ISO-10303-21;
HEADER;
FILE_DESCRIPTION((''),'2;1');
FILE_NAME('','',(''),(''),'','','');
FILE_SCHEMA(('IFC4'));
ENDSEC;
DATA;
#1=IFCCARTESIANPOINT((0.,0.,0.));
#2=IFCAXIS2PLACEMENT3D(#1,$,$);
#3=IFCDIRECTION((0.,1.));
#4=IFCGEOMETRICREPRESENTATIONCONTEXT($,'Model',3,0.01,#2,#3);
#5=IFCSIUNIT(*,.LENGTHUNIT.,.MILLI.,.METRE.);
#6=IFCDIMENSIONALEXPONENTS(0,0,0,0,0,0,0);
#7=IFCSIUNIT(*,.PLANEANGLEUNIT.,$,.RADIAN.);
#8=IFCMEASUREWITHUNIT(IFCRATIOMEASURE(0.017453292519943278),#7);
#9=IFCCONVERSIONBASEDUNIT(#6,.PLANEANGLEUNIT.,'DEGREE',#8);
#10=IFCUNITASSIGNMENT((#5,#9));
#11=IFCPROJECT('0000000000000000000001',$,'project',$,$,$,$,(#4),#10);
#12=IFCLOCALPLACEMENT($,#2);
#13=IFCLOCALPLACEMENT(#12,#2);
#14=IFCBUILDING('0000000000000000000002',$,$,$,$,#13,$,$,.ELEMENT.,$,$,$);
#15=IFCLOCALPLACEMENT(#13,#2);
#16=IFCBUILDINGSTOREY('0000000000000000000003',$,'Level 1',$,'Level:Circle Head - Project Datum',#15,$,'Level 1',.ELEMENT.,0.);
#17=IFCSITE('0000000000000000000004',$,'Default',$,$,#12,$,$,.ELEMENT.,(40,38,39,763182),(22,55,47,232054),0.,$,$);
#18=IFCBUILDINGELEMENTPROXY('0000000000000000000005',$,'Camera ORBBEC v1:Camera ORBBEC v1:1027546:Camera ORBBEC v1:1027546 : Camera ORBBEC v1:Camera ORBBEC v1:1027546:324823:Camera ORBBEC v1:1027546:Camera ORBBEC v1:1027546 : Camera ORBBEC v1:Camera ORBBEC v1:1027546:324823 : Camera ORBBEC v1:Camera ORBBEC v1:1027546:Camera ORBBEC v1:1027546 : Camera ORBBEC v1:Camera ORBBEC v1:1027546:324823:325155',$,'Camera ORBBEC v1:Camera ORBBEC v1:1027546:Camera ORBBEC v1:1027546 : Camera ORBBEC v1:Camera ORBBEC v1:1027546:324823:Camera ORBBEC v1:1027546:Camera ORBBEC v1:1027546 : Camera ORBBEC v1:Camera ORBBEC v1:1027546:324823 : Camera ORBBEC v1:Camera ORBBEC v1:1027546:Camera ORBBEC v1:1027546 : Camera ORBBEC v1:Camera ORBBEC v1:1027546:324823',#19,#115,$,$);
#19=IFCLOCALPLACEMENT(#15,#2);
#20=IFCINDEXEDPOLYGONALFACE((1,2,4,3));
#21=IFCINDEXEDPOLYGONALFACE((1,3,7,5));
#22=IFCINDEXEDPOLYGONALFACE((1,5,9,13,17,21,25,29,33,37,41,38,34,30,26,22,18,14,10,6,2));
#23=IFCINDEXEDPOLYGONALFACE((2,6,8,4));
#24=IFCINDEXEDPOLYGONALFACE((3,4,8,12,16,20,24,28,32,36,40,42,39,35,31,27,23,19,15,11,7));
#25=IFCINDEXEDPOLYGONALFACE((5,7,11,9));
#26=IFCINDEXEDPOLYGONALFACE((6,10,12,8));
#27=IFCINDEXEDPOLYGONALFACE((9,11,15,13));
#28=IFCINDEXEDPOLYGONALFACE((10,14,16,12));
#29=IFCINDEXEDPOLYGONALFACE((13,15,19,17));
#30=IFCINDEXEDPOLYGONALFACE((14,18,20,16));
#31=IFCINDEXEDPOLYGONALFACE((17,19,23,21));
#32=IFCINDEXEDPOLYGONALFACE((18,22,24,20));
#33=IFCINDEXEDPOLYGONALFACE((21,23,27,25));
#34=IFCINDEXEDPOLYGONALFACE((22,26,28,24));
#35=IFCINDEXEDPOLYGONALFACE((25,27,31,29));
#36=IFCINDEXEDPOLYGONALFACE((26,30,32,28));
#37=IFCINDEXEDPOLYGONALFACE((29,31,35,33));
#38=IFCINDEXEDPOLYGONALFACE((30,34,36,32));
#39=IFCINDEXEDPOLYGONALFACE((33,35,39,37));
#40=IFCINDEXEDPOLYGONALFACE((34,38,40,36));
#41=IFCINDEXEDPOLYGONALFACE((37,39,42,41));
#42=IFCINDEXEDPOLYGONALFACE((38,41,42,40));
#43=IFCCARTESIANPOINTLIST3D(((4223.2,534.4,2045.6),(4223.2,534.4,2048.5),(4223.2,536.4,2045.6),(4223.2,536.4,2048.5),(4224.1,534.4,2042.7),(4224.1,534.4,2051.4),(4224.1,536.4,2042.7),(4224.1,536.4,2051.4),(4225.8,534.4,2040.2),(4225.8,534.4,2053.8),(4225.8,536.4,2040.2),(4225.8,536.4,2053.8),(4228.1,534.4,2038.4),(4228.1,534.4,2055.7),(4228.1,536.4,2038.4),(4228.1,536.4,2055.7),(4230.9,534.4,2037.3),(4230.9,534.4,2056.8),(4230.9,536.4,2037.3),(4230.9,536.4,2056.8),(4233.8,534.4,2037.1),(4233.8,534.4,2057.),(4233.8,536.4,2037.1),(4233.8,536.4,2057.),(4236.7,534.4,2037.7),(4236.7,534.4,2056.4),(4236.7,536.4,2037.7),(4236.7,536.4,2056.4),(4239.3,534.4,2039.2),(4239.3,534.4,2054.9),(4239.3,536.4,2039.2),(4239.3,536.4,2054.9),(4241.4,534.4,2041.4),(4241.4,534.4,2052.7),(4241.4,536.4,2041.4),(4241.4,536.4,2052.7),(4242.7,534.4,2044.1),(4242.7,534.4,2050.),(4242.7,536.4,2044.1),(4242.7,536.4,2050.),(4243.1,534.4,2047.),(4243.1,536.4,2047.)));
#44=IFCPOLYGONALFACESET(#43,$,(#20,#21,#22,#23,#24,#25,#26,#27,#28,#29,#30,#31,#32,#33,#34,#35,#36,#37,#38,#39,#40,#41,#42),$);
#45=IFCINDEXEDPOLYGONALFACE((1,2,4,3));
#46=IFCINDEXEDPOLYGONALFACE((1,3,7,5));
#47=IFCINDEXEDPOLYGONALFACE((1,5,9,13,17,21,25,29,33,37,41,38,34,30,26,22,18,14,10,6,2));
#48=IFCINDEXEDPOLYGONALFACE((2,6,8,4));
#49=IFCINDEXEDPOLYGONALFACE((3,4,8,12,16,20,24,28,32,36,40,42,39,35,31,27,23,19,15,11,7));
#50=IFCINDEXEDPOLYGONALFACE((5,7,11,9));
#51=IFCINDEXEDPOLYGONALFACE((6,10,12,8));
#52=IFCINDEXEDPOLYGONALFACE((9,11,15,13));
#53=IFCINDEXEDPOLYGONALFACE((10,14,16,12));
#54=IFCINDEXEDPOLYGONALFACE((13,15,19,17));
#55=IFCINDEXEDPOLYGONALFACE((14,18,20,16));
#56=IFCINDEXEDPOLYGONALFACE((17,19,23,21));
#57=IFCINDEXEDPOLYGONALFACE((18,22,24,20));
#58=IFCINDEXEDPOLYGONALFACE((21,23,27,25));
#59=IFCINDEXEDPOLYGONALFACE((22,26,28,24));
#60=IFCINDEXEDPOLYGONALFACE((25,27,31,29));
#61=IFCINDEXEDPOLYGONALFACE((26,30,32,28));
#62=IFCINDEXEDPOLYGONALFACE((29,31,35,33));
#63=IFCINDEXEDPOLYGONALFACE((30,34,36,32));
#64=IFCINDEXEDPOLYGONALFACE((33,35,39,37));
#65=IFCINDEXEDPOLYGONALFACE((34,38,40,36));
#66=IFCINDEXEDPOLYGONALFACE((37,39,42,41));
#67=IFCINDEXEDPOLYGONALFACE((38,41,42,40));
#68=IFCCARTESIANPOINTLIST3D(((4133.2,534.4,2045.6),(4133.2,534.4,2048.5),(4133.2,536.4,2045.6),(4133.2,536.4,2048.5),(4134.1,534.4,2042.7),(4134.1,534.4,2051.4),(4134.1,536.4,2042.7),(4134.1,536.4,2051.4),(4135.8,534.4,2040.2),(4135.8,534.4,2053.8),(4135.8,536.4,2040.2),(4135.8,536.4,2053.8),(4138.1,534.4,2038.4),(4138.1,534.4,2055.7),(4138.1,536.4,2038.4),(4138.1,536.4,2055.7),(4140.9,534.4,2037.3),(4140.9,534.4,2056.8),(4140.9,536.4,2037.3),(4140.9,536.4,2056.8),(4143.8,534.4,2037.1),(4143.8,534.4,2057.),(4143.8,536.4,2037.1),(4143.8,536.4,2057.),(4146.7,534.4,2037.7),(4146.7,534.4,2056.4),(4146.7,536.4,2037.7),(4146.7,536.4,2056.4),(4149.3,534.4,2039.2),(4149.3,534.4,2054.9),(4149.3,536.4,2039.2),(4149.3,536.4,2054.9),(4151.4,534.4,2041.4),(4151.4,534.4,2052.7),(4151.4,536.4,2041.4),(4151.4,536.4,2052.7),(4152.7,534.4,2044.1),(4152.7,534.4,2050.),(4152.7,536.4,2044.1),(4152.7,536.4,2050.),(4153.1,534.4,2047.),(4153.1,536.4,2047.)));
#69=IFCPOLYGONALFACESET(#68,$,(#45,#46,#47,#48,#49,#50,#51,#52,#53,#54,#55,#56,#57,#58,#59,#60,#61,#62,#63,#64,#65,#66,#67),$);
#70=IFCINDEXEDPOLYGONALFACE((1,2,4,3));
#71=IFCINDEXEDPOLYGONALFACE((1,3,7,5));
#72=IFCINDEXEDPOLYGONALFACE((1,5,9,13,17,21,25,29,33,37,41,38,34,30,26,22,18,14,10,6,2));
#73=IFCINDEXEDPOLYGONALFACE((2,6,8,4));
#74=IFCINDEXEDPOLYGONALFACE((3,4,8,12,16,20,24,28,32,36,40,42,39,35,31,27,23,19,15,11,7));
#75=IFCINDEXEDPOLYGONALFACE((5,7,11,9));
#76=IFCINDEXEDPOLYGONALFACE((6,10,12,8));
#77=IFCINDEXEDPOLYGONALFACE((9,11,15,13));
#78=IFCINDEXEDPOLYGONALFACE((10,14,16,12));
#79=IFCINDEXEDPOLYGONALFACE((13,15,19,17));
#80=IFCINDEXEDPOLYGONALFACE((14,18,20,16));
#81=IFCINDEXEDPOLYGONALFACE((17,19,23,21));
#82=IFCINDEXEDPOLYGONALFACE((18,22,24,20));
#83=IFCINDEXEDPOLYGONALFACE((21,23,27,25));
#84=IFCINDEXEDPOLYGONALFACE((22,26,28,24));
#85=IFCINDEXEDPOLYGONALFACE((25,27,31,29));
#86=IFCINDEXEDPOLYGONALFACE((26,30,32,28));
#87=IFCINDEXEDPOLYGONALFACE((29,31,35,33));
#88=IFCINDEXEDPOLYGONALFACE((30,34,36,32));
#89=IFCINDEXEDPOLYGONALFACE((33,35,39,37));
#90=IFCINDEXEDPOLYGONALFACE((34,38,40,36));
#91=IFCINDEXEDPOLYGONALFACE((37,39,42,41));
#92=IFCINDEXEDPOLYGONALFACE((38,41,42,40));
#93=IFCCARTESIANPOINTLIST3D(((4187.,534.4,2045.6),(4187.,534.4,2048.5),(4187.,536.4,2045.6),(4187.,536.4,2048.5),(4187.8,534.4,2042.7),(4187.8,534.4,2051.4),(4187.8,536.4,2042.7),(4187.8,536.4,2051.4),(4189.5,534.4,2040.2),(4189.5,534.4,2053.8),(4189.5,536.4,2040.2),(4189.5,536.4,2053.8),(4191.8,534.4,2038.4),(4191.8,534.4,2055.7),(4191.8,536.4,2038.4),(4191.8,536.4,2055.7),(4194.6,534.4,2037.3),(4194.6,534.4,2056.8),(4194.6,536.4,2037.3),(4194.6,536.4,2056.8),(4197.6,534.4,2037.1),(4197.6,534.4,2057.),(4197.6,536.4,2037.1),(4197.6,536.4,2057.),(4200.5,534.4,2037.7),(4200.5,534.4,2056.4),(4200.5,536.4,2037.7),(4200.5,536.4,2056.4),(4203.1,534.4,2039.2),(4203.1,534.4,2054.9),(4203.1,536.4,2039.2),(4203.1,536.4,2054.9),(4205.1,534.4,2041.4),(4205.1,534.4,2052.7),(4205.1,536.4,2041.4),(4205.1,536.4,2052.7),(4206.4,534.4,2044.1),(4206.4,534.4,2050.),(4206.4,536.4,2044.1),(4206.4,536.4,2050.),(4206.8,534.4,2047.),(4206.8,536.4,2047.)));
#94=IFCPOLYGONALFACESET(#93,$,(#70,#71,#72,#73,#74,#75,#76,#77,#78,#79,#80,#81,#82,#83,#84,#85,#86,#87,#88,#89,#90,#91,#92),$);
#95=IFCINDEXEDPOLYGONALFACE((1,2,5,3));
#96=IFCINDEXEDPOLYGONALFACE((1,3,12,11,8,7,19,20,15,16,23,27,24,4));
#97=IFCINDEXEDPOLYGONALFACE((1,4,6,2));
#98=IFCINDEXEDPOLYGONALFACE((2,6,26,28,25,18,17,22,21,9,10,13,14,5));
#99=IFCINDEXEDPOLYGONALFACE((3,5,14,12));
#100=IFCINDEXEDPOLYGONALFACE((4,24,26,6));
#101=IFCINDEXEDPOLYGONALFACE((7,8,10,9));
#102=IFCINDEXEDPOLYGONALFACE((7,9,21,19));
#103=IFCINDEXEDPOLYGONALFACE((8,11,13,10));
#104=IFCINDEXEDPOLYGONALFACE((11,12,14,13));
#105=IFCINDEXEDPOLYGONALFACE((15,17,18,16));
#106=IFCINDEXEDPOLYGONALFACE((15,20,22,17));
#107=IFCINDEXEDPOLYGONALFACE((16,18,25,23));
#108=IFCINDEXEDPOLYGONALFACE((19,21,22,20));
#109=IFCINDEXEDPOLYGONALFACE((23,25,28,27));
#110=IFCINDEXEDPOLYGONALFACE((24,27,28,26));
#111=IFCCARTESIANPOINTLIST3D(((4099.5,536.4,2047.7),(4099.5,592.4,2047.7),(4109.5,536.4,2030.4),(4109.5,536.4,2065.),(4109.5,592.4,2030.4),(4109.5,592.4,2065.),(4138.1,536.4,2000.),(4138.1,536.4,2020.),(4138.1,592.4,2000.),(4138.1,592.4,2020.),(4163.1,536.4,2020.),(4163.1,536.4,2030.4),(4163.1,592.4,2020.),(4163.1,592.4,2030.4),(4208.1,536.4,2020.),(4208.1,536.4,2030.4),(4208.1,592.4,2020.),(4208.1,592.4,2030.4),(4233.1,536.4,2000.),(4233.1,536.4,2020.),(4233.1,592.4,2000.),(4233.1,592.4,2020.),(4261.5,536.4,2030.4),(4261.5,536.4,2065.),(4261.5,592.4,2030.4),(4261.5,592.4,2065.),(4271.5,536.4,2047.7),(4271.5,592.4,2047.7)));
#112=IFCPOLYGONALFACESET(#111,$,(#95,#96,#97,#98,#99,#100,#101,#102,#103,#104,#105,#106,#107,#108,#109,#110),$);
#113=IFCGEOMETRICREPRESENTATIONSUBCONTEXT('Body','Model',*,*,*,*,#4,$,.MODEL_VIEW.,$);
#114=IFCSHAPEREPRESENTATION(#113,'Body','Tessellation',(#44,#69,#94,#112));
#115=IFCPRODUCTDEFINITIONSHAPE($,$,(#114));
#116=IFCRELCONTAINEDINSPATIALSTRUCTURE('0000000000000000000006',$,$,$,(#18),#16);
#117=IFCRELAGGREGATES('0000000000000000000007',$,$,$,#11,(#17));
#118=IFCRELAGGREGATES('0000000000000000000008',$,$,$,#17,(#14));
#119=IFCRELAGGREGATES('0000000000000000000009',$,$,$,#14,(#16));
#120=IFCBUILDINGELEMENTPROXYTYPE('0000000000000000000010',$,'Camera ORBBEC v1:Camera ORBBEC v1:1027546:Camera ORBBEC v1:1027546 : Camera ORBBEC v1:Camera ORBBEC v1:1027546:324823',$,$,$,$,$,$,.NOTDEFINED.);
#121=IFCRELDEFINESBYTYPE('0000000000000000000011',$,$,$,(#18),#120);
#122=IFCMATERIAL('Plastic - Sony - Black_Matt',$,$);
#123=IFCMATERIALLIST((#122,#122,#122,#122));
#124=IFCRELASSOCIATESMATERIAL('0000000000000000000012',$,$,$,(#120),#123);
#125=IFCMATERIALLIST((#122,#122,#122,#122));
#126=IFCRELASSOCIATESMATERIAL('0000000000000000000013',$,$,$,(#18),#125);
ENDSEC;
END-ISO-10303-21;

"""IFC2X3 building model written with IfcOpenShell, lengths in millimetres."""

from ifc_helpers import new_model, entity, si_unit, converted_unit, direction, frame, origin, origin_2d_with_axis, place, context, subcontext, project, spatial, polyline, circle, outline, extrude, source, transform, mapped, material, material_list, type_object, type_shapes, element, save


model = new_model("IFC2X3")

# Units and contexts
model_context = context("Model", 3, precision=0.01, world=origin(), true_north=direction((0.0, 1.0)))
body_context = subcontext(model_context, "Body", "Model", "MODEL_VIEW")
ifc_project = project(units=[si_unit("LENGTHUNIT", "METRE", prefix="MILLI"), converted_unit("PLANEANGLEUNIT", "DEGREE", entity("IfcRatioMeasure", 0.017453292519943278), si_unit("PLANEANGLEUNIT", "RADIAN"), dimensions=[0, 0, 0, 0, 0, 0, 0])], contexts=[model_context])

# Site, building, storey
site_placement = place(None, origin())
site = spatial("IfcSite", under=ifc_project, at=site_placement, Name="Default", CompositionType="ELEMENT", RefLatitude=(40, 38, 39, 763182), RefLongitude=(22, 55, 47, 232054), RefElevation=0.0)
building_placement = place(site_placement, origin())
building = spatial("IfcBuilding", under=site, at=building_placement, CompositionType="ELEMENT")
storey_placement = place(building_placement, origin())
storey = spatial("IfcBuildingStorey", under=building, at=storey_placement, Name="Level 1", ObjectType="Level:Circle Head - Project Datum", LongName="Level 1", CompositionType="ELEMENT", Elevation=0.0)

# Building element proxy
ifc_material_1 = material(Name="Plastic - Sony - Black_Matt")
ifc_material_list_1 = material_list([ifc_material_1, ifc_material_1, ifc_material_1, ifc_material_1])
ifc_material_list_2 = material_list([ifc_material_1, ifc_material_1, ifc_material_1, ifc_material_1])
building_element_proxy_type_1 = type_object("IfcBuildingElementProxyType", Name="Camera ORBBEC v1:Camera ORBBEC v1:1027546:Camera ORBBEC v1:1027546 : Camera ORBBEC v1:Camera ORBBEC v1:1027546:324823", PredefinedType="NOTDEFINED", material=ifc_material_list_2)
shared_shape_1 = source(origin(), body_context, "Body", "SweptSolid", [
    extrude(circle(Radius=10.0, at=origin_2d_with_axis()), frame((4233.1, 534.4, 2047.0), z_axis=(0.0, 1.0, 0.0), x_axis=(1.0, 0.0, 0.0)), (0.0, 0.0, 1.0), 2.0),
    extrude(circle(Radius=10.0, at=origin_2d_with_axis()), frame((4143.1, 534.4, 2047.0), z_axis=(0.0, 1.0, 0.0), x_axis=(1.0, 0.0, 0.0)), (0.0, 0.0, 1.0), 2.0),
    extrude(circle(Radius=10.0, at=origin_2d_with_axis()), frame((4196.8, 534.4, 2047.0), z_axis=(0.0, 1.0, 0.0), x_axis=(1.0, 0.0, 0.0)), (0.0, 0.0, 1.0), 2.0),
    extrude(outline(polyline([(8.1, -83.0), (28.1, -83.0), (38.1, -65.7), (11.4, -19.5), (20.3, -14.3), (32.8, -35.9), (50.2, -25.9), (2.7, 56.3), (-14.7, 46.3), (-2.2, 24.7), (-11.1, 19.5), (-37.9, 65.9), (-57.9, 65.9), (-67.9, 48.6), (8.1, -83.0)])), frame((4185.6, 536.4, 2030.5), z_axis=(0.0, 1.0, 0.0), x_axis=(0.5, 0.0, -0.866025)), (0.0, 0.0, 1.0), 56.0),
])
type_shapes(building_element_proxy_type_1, [shared_shape_1])
proxy_1_placement = place(storey_placement, origin())
element("IfcBuildingElementProxy", 1, at=proxy_1_placement, inside=storey, type_object=building_element_proxy_type_1, material=ifc_material_list_1, Name="Camera ORBBEC v1:Camera ORBBEC v1:1027546:Camera ORBBEC v1:1027546 : Camera ORBBEC v1:Camera ORBBEC v1:1027546:324823:Camera ORBBEC v1:1027546:Camera ORBBEC v1:1027546 : Camera ORBBEC v1:Camera ORBBEC v1:1027546:324823 : Camera ORBBEC v1:Camera ORBBEC v1:1027546:Camera ORBBEC v1:1027546 : Camera ORBBEC v1:Camera ORBBEC v1:1027546:324823:325155", ObjectType="Camera ORBBEC v1:Camera ORBBEC v1:1027546:Camera ORBBEC v1:1027546 : Camera ORBBEC v1:Camera ORBBEC v1:1027546:324823:Camera ORBBEC v1:1027546:Camera ORBBEC v1:1027546 : Camera ORBBEC v1:Camera ORBBEC v1:1027546:324823 : Camera ORBBEC v1:Camera ORBBEC v1:1027546:Camera ORBBEC v1:1027546 : Camera ORBBEC v1:Camera ORBBEC v1:1027546:324823", context=body_context, shape_type="MappedRepresentation", body=[
    mapped(shared_shape_1, transform((0.0, 0.0, 0.0), scale=1.0)),
])

save(model, "model.ifc")
